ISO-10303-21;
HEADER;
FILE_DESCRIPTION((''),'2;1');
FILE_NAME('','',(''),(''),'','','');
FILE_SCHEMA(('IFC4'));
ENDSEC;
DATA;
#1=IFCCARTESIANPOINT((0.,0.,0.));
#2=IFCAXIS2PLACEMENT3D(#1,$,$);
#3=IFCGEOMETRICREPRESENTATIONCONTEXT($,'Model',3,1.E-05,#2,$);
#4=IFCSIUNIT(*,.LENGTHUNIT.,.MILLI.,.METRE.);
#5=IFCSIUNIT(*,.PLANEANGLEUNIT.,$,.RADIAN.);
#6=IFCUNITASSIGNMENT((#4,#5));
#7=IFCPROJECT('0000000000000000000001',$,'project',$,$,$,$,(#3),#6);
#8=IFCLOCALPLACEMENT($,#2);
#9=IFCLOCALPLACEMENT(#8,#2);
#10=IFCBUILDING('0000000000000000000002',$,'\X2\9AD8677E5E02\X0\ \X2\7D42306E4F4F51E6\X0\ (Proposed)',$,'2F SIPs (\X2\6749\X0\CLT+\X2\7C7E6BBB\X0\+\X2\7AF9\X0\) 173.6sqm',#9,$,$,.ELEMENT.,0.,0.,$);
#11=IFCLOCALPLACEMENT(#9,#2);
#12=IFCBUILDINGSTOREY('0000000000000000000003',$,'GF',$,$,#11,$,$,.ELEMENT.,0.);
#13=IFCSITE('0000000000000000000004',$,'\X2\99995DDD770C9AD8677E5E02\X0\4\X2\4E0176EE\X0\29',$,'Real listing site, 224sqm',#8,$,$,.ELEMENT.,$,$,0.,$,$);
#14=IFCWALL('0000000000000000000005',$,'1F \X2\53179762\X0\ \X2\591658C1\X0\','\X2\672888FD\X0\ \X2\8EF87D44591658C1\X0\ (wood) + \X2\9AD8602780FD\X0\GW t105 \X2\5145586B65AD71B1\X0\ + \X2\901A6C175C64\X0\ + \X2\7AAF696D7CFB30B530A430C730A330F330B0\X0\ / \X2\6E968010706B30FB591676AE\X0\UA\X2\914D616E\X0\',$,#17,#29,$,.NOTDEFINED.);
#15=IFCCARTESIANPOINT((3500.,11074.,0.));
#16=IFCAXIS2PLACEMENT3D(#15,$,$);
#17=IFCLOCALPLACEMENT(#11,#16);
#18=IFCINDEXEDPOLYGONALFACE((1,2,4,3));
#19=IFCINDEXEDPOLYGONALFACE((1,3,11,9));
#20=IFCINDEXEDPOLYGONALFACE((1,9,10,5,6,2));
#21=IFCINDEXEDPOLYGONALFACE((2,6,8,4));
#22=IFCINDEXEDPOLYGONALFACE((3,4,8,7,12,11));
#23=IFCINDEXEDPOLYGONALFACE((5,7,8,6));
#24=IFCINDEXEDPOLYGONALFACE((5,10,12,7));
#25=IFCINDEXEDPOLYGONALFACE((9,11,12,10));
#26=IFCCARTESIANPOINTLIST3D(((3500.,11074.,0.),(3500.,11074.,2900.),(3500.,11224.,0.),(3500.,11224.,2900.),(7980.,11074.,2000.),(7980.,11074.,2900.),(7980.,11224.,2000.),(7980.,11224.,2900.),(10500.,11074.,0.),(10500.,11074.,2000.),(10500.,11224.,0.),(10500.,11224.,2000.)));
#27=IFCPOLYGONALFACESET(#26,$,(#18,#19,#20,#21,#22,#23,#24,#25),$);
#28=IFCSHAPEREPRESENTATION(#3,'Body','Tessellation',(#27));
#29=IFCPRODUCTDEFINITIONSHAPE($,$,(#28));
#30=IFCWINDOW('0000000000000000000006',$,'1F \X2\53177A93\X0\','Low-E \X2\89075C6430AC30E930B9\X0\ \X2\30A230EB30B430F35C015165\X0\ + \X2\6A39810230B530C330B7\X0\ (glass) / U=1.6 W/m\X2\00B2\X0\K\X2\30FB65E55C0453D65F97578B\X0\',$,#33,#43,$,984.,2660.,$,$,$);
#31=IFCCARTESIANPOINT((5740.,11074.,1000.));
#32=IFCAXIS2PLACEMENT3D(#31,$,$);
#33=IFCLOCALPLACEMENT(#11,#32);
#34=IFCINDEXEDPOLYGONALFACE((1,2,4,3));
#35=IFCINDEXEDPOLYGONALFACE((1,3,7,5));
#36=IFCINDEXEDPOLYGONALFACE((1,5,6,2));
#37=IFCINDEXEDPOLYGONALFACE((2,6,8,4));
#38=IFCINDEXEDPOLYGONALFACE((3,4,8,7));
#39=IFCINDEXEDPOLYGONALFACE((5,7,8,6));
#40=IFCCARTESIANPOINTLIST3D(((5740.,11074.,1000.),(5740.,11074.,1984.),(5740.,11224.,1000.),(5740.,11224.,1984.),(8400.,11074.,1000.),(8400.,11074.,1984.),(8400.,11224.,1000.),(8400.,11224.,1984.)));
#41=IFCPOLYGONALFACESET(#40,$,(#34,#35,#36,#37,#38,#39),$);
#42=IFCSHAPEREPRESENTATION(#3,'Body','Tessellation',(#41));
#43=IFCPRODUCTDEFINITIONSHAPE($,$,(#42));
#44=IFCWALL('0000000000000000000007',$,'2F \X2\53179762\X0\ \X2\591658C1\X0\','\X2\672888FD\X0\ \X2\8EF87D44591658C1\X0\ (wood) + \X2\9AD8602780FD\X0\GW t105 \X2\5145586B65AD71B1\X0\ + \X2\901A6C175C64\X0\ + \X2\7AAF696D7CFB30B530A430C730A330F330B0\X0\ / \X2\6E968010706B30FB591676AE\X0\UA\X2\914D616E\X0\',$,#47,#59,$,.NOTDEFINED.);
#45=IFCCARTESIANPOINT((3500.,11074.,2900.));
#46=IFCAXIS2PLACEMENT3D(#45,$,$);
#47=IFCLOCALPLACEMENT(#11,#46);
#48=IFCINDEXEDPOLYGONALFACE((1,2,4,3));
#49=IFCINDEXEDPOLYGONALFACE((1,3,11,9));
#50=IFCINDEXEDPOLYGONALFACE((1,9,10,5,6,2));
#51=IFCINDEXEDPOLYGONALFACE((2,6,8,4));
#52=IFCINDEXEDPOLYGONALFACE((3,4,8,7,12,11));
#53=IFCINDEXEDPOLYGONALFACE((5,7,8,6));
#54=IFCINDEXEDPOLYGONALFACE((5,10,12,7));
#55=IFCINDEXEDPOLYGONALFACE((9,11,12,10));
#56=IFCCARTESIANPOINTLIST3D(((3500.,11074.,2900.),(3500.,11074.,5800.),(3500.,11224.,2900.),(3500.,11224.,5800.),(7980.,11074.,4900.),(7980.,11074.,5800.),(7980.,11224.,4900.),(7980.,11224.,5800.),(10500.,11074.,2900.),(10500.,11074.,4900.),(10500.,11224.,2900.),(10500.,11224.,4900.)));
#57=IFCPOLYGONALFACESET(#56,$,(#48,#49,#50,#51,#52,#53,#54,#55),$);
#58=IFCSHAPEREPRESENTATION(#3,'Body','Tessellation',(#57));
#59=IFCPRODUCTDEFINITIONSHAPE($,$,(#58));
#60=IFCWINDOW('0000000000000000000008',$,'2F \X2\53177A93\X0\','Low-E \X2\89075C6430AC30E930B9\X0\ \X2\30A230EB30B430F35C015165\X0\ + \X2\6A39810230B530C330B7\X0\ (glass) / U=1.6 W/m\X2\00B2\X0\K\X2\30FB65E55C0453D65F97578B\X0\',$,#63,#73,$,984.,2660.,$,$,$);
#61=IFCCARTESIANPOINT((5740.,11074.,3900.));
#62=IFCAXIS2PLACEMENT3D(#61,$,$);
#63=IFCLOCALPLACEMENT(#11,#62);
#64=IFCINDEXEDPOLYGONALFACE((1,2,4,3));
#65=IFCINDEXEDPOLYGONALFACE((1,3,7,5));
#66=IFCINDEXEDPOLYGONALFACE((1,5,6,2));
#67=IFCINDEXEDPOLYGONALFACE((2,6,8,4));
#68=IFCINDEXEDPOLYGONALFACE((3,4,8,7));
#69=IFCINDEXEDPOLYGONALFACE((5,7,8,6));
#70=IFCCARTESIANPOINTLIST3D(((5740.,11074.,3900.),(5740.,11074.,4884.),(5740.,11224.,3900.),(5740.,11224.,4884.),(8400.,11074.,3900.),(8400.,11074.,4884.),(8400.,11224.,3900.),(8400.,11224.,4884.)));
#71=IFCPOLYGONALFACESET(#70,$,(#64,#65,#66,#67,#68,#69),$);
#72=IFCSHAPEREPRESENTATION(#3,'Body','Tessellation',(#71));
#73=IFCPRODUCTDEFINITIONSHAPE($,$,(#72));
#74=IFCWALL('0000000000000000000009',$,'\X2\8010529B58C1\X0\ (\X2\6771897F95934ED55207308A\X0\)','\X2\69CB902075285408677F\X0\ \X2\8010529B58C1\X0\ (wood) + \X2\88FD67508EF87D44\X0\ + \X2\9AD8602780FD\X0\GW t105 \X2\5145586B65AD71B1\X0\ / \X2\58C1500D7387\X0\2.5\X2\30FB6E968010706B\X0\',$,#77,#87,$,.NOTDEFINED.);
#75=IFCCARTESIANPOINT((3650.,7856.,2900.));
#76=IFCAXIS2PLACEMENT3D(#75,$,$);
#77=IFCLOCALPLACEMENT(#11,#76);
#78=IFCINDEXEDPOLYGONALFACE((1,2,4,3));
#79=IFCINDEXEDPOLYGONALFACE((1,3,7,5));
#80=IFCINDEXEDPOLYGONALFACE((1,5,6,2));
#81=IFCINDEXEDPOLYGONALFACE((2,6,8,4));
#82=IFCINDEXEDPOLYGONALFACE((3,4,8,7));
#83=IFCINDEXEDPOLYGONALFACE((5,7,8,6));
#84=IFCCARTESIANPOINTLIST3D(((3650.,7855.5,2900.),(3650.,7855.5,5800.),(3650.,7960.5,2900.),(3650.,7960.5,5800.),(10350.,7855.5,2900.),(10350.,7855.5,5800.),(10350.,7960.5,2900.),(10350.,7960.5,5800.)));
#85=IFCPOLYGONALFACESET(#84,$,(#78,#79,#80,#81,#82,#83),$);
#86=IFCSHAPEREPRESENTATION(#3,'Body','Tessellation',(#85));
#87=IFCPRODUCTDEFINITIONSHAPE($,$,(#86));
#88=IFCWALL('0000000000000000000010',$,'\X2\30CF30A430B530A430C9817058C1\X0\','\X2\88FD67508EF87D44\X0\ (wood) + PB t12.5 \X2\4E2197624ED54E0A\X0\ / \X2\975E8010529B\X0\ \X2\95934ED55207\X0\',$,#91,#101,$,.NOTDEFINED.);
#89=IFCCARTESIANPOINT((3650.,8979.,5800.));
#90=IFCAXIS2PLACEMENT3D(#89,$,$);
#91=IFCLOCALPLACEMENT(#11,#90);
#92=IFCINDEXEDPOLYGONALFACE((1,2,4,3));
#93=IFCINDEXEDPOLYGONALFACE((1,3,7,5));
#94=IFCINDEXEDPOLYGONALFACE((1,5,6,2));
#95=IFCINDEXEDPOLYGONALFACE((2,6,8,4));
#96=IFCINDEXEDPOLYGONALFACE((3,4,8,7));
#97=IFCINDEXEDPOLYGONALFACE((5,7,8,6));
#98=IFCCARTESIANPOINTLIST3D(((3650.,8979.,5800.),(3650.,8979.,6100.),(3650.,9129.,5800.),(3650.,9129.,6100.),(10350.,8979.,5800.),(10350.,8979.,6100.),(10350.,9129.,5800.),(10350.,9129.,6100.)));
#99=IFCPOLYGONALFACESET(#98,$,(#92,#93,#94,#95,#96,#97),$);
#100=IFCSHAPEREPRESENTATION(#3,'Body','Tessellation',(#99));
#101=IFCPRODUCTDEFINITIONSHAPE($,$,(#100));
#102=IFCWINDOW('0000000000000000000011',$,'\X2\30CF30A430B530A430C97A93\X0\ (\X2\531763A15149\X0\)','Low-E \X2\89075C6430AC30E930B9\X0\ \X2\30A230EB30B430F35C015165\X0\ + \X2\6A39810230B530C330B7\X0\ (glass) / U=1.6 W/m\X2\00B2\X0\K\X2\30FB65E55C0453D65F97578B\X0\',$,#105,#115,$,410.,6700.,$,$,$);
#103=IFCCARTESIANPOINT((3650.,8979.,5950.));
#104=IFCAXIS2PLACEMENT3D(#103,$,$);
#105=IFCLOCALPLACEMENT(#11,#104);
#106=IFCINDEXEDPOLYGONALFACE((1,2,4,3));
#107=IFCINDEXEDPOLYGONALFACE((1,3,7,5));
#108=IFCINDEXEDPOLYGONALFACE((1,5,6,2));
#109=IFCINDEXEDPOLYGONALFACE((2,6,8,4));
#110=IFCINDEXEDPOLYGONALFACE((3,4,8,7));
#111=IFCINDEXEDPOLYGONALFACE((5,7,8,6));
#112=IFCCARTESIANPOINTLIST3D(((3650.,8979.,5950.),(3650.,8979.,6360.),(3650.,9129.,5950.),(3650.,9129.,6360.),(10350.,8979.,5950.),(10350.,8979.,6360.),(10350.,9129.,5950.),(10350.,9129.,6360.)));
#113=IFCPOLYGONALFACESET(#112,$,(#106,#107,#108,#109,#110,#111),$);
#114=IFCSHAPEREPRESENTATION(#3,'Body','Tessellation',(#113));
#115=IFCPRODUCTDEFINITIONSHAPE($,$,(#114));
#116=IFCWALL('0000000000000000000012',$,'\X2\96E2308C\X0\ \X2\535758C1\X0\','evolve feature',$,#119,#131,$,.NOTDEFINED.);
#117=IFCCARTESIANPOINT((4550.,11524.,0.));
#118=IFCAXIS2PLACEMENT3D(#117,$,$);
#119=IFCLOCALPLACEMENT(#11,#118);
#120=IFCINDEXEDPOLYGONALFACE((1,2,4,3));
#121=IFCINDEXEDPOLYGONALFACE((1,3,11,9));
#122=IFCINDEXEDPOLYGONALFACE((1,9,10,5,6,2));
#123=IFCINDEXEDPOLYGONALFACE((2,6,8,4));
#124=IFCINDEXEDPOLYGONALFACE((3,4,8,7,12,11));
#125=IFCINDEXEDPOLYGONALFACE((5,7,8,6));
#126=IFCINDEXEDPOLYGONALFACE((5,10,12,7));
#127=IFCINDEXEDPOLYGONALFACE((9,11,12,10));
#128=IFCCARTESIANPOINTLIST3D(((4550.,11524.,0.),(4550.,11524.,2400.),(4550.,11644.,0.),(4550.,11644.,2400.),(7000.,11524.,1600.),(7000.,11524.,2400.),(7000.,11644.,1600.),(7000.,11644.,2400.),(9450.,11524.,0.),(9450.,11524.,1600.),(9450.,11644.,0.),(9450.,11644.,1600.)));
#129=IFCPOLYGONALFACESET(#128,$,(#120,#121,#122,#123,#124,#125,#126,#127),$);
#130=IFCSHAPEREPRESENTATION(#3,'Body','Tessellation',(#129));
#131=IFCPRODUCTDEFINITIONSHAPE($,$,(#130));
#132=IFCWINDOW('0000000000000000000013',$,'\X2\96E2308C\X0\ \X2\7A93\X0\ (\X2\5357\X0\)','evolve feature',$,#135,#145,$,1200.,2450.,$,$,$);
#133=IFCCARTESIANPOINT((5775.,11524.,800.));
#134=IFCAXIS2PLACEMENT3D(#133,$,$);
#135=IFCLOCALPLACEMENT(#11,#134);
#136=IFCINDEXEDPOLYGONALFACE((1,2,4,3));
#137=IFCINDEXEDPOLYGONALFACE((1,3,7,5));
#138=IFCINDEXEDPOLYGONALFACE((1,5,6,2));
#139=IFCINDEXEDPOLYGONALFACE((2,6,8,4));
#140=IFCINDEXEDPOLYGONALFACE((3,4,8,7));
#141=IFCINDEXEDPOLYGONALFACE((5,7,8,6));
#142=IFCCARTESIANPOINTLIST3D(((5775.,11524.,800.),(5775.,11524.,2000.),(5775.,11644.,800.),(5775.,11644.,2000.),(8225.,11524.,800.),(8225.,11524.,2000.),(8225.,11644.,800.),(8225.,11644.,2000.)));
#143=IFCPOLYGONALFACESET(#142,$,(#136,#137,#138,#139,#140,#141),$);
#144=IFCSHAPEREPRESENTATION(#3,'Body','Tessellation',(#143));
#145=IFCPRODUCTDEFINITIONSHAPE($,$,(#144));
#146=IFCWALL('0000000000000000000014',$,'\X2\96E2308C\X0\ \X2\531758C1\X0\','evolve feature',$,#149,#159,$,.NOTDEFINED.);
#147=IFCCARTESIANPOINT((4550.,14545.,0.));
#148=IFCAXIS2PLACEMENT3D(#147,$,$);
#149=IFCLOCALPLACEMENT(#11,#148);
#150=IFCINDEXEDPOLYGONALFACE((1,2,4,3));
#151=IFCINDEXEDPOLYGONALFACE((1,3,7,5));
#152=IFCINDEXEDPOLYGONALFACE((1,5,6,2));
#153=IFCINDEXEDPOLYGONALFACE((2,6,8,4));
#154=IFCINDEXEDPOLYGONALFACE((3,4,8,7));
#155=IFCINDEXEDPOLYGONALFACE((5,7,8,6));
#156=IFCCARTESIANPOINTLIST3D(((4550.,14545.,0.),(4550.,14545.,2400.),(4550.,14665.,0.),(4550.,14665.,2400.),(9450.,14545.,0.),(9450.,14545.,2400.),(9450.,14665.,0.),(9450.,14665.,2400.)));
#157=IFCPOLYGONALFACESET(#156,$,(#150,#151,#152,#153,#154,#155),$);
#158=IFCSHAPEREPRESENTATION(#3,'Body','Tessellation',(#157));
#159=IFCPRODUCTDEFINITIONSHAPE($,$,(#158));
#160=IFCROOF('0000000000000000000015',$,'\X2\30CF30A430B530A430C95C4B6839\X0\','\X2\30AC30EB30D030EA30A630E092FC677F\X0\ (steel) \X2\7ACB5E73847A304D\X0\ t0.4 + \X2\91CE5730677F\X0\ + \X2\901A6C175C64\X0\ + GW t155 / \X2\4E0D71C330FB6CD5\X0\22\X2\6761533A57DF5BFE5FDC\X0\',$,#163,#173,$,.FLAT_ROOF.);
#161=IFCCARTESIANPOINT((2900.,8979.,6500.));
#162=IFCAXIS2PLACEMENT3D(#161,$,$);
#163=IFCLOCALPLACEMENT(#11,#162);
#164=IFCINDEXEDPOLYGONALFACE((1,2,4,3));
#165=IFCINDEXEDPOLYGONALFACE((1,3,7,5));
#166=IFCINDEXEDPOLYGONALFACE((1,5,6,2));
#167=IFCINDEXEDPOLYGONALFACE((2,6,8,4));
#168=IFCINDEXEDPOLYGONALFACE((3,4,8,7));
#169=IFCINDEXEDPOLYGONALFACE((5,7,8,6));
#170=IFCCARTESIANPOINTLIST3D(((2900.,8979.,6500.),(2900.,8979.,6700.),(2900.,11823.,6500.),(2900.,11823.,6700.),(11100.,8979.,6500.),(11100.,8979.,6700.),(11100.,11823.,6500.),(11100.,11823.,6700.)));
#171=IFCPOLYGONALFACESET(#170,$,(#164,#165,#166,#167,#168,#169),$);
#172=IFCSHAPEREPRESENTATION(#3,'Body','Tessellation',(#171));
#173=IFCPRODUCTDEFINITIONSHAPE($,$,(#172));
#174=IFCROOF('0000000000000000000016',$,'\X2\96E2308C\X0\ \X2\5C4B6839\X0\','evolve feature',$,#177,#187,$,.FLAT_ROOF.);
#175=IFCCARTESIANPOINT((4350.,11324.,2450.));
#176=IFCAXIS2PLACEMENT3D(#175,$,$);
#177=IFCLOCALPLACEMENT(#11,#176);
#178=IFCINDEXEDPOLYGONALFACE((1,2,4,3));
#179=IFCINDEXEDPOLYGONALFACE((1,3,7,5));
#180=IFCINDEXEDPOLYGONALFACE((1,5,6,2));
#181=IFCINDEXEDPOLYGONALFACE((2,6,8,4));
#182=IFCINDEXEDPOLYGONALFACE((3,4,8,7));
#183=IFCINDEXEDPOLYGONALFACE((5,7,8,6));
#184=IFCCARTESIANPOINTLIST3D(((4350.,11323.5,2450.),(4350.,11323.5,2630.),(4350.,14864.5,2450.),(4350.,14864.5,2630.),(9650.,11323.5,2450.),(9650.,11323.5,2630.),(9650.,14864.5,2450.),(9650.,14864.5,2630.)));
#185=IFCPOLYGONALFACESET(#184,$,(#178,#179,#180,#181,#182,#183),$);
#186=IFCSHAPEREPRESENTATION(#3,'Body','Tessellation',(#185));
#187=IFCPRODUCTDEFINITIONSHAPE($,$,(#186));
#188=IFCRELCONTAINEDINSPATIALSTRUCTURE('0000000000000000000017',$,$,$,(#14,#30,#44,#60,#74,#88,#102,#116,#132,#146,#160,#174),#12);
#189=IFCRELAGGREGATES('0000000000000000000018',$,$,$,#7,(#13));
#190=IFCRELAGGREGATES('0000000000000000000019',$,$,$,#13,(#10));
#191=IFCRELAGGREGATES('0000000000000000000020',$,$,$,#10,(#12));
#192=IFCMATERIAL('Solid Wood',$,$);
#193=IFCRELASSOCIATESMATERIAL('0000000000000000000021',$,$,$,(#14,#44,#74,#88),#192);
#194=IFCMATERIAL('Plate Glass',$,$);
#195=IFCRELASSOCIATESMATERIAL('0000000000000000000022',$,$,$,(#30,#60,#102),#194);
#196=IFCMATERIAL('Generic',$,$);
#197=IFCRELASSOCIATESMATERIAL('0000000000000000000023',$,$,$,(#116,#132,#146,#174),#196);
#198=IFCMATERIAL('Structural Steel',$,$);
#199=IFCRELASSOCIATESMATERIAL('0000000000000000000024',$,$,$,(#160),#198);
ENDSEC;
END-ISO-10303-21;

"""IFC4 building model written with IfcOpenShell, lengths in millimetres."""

from ifc_helpers import new_model, si_unit, frame, frame_2d, origin, place, context, project, spatial, rectangle, extrude, material, element, fill, save


model = new_model("IFC4")

# Units and contexts
model_context = context("Model", 3, precision=1e-05, world=origin())
ifc_project = project(units=[si_unit("LENGTHUNIT", "METRE", prefix="MILLI"), si_unit("PLANEANGLEUNIT", "RADIAN")], contexts=[model_context])

# Site, building, storey
site_placement = place(None, origin())
site = spatial("IfcSite", under=ifc_project, at=site_placement, Name="香川県高松市4丁目29", ObjectType="Real listing site, 224sqm", CompositionType="ELEMENT", RefElevation=0.0)
building_placement = place(site_placement, origin())
building = spatial("IfcBuilding", under=site, at=building_placement, Name="高松市 終の住処 (Proposed)", ObjectType="2F SIPs (杉CLT+籾殻+竹) 173.6sqm", CompositionType="ELEMENT", ElevationOfRefHeight=0.0, ElevationOfTerrain=0.0)
storey_placement = place(building_placement, origin())
storey = spatial("IfcBuildingStorey", under=building, at=storey_placement, Name="GF", CompositionType="ELEMENT", Elevation=0.0)

# Shared definitions
ifc_material_1 = material(Name="Generic")

# Wall, opening, window
ifc_material_2 = material(Name="Solid Wood")
wall_1_placement = place(storey_placement, frame((3500.0, 11074.0, 0.0)))
wall_1 = element("IfcWall", 1, at=wall_1_placement, inside=storey, material=ifc_material_2, Name="1F 北面 外壁", Description="木製 軸組外壁 (wood) + 高性能GW t105 充填断熱 + 通気層 + 窯業系サイディング / 準耐火・外皮UA配慮", PredefinedType="NOTDEFINED", context=model_context, shape_type="SweptSolid", body=[
    extrude(rectangle(XDim=7000.0, YDim=150.0, at=frame_2d((3500.0, 75.0))), frame((3500.0, 11074.0, 0.0)), (0.0, 0.0, 1.0), 2900.0),
])
opening_1_placement = place(storey_placement, frame((5740.0, 11074.0, 1000.0)))
opening_1 = element("IfcOpeningElement", 2, at=opening_1_placement, cuts=wall_1, PredefinedType="NOTDEFINED", context=model_context, shape_type="SweptSolid", body=[
    extrude(rectangle(XDim=2660.0, YDim=150.0, at=frame_2d((1330.0, 75.0))), frame((5740.0, 11074.0, 1000.0)), (0.0, 0.0, 1.0), 984.0),
])
ifc_material_3 = material(Name="Plate Glass")
window_1_placement = place(storey_placement, frame((5740.0, 11074.0, 1000.0)))
window_1 = element("IfcWindow", 3, at=window_1_placement, inside=storey, material=ifc_material_3, Name="1F 北窓", Description="Low-E 複層ガラス アルゴン封入 + 樹脂サッシ (glass) / U=1.6 W/m²K・日射取得型", OverallHeight=984.0, OverallWidth=2660.0, context=model_context, shape_type="SweptSolid", body=[
    extrude(rectangle(XDim=2660.0, YDim=150.0, at=frame_2d((1330.0, 75.0))), frame((5740.0, 11074.0, 1000.0)), (0.0, 0.0, 1.0), 984.0),
])
fill(opening_1, window_1)

# Wall, opening, window
wall_2_placement = place(storey_placement, frame((3500.0, 11074.0, 2900.0)))
wall_2 = element("IfcWall", 4, at=wall_2_placement, inside=storey, material=ifc_material_2, Name="2F 北面 外壁", Description="木製 軸組外壁 (wood) + 高性能GW t105 充填断熱 + 通気層 + 窯業系サイディング / 準耐火・外皮UA配慮", PredefinedType="NOTDEFINED", context=model_context, shape_type="SweptSolid", body=[
    extrude(rectangle(XDim=7000.0, YDim=150.0, at=frame_2d((3500.0, 75.0))), frame((3500.0, 11074.0, 2900.0)), (0.0, 0.0, 1.0), 2900.0),
])
opening_2_placement = place(storey_placement, frame((5740.0, 11074.0, 3900.0)))
opening_2 = element("IfcOpeningElement", 5, at=opening_2_placement, cuts=wall_2, PredefinedType="NOTDEFINED", context=model_context, shape_type="SweptSolid", body=[
    extrude(rectangle(XDim=2660.0, YDim=150.0, at=frame_2d((1330.0, 75.0))), frame((5740.0, 11074.0, 3900.0)), (0.0, 0.0, 1.0), 984.0),
])
window_2_placement = place(storey_placement, frame((5740.0, 11074.0, 3900.0)))
window_2 = element("IfcWindow", 6, at=window_2_placement, inside=storey, material=ifc_material_3, Name="2F 北窓", Description="Low-E 複層ガラス アルゴン封入 + 樹脂サッシ (glass) / U=1.6 W/m²K・日射取得型", OverallHeight=984.0, OverallWidth=2660.0, context=model_context, shape_type="SweptSolid", body=[
    extrude(rectangle(XDim=2660.0, YDim=150.0, at=frame_2d((1330.0, 75.0))), frame((5740.0, 11074.0, 3900.0)), (0.0, 0.0, 1.0), 984.0),
])
fill(opening_2, window_2)

# Wall
wall_3_placement = place(storey_placement, frame((3650.0, 7856.0, 2900.0)))
element("IfcWall", 7, at=wall_3_placement, inside=storey, material=ifc_material_2, Name="耐力壁 (東西間仕切り)", Description="構造用合板 耐力壁 (wood) + 製材軸組 + 高性能GW t105 充填断熱 / 壁倍率2.5・準耐火", PredefinedType="NOTDEFINED", context=model_context, shape_type="SweptSolid", body=[
    extrude(rectangle(XDim=6700.0, YDim=105.0, at=frame_2d((3350.0, 52.0))), frame((3650.0, 7856.0, 2900.0)), (0.0, 0.0, 1.0), 2900.0),
])

# Walls, openings, windows
wall_4_placement = place(storey_placement, frame((3650.0, 8979.0, 5800.0)))
wall_4 = element("IfcWall", 8, at=wall_4_placement, inside=storey, material=ifc_material_2, Name="ハイサイド腰壁", Description="製材軸組 (wood) + PB t12.5 両面仕上 / 非耐力 間仕切", PredefinedType="NOTDEFINED", context=model_context, shape_type="SweptSolid", body=[
    extrude(rectangle(XDim=6700.0, YDim=150.0, at=frame_2d((3350.0, 75.0))), frame((3650.0, 8979.0, 5800.0)), (0.0, 0.0, 1.0), 700.0),
])
opening_3_placement = place(storey_placement, frame((3650.0, 8979.0, 5950.0)))
opening_3 = element("IfcOpeningElement", 9, at=opening_3_placement, cuts=wall_4, PredefinedType="NOTDEFINED", context=model_context, shape_type="SweptSolid", body=[
    extrude(rectangle(XDim=6700.0, YDim=150.0, at=frame_2d((3350.0, 75.0))), frame((3650.0, 8979.0, 5950.0)), (0.0, 0.0, 1.0), 410.0),
])
window_3_placement = place(storey_placement, frame((3650.0, 8979.0, 5950.0)))
window_3 = element("IfcWindow", 10, at=window_3_placement, inside=storey, material=ifc_material_3, Name="ハイサイド窓 (北採光)", Description="Low-E 複層ガラス アルゴン封入 + 樹脂サッシ (glass) / U=1.6 W/m²K・日射取得型", OverallHeight=410.0, OverallWidth=6700.0, context=model_context, shape_type="SweptSolid", body=[
    extrude(rectangle(XDim=6700.0, YDim=150.0, at=frame_2d((3350.0, 75.0))), frame((3650.0, 8979.0, 5950.0)), (0.0, 0.0, 1.0), 410.0),
])
fill(opening_3, window_3)
wall_5_placement = place(storey_placement, frame((4550.0, 11524.0, 0.0)))
wall_5 = element("IfcWall", 11, at=wall_5_placement, inside=storey, material=ifc_material_1, Name="離れ 南壁", Description="evolve feature", PredefinedType="NOTDEFINED", context=model_context, shape_type="SweptSolid", body=[
    extrude(rectangle(XDim=4900.0, YDim=120.0, at=frame_2d((2450.0, 60.0))), frame((4550.0, 11524.0, 0.0)), (0.0, 0.0, 1.0), 2400.0),
])
opening_4_placement = place(storey_placement, frame((5775.0, 11524.0, 800.0)))
opening_4 = element("IfcOpeningElement", 12, at=opening_4_placement, cuts=wall_5, PredefinedType="NOTDEFINED", context=model_context, shape_type="SweptSolid", body=[
    extrude(rectangle(XDim=2450.0, YDim=120.0, at=frame_2d((1225.0, 60.0))), frame((5775.0, 11524.0, 800.0)), (0.0, 0.0, 1.0), 1200.0),
])
window_4_placement = place(storey_placement, frame((5775.0, 11524.0, 800.0)))
window_4 = element("IfcWindow", 13, at=window_4_placement, inside=storey, material=ifc_material_1, Name="離れ 窓 (南)", Description="evolve feature", OverallHeight=1200.0, OverallWidth=2450.0, context=model_context, shape_type="SweptSolid", body=[
    extrude(rectangle(XDim=2450.0, YDim=120.0, at=frame_2d((1225.0, 60.0))), frame((5775.0, 11524.0, 800.0)), (0.0, 0.0, 1.0), 1200.0),
])
fill(opening_4, window_4)

# Wall
wall_6_placement = place(storey_placement, frame((4550.0, 14545.0, 0.0)))
element("IfcWall", 14, at=wall_6_placement, inside=storey, material=ifc_material_1, Name="離れ 北壁", Description="evolve feature", PredefinedType="NOTDEFINED", context=model_context, shape_type="SweptSolid", body=[
    extrude(rectangle(XDim=4900.0, YDim=120.0, at=frame_2d((2450.0, 60.0))), frame((4550.0, 14545.0, 0.0)), (0.0, 0.0, 1.0), 2400.0),
])

# Roofs
ifc_material_4 = material(Name="Structural Steel")
roof_1_placement = place(storey_placement, frame((2900.0, 8979.0, 6500.0)))
element("IfcRoof", 15, at=roof_1_placement, inside=storey, material=ifc_material_4, Name="ハイサイド屋根", Description="ガルバリウム鋼板 (steel) 立平葺き t0.4 + 野地板 + 通気層 + GW t155 / 不燃・法22条区域対応", PredefinedType="FLAT_ROOF", context=model_context, shape_type="SweptSolid", body=[
    extrude(rectangle(XDim=8200.0, YDim=2844.0, at=frame_2d((4100.0, 1422.0))), frame((2900.0, 8979.0, 6500.0)), (0.0, 0.0, 1.0), 200.0),
])
roof_2_placement = place(storey_placement, frame((4350.0, 11324.0, 2450.0)))
element("IfcRoof", 16, at=roof_2_placement, inside=storey, material=ifc_material_1, Name="離れ 屋根", Description="evolve feature", PredefinedType="FLAT_ROOF", context=model_context, shape_type="SweptSolid", body=[
    extrude(rectangle(XDim=5300.0, YDim=3541.0, at=frame_2d((2650.0, 1770.0))), frame((4350.0, 11324.0, 2450.0)), (0.0, 0.0, 1.0), 180.0),
])

save(model, "model.ifc")
